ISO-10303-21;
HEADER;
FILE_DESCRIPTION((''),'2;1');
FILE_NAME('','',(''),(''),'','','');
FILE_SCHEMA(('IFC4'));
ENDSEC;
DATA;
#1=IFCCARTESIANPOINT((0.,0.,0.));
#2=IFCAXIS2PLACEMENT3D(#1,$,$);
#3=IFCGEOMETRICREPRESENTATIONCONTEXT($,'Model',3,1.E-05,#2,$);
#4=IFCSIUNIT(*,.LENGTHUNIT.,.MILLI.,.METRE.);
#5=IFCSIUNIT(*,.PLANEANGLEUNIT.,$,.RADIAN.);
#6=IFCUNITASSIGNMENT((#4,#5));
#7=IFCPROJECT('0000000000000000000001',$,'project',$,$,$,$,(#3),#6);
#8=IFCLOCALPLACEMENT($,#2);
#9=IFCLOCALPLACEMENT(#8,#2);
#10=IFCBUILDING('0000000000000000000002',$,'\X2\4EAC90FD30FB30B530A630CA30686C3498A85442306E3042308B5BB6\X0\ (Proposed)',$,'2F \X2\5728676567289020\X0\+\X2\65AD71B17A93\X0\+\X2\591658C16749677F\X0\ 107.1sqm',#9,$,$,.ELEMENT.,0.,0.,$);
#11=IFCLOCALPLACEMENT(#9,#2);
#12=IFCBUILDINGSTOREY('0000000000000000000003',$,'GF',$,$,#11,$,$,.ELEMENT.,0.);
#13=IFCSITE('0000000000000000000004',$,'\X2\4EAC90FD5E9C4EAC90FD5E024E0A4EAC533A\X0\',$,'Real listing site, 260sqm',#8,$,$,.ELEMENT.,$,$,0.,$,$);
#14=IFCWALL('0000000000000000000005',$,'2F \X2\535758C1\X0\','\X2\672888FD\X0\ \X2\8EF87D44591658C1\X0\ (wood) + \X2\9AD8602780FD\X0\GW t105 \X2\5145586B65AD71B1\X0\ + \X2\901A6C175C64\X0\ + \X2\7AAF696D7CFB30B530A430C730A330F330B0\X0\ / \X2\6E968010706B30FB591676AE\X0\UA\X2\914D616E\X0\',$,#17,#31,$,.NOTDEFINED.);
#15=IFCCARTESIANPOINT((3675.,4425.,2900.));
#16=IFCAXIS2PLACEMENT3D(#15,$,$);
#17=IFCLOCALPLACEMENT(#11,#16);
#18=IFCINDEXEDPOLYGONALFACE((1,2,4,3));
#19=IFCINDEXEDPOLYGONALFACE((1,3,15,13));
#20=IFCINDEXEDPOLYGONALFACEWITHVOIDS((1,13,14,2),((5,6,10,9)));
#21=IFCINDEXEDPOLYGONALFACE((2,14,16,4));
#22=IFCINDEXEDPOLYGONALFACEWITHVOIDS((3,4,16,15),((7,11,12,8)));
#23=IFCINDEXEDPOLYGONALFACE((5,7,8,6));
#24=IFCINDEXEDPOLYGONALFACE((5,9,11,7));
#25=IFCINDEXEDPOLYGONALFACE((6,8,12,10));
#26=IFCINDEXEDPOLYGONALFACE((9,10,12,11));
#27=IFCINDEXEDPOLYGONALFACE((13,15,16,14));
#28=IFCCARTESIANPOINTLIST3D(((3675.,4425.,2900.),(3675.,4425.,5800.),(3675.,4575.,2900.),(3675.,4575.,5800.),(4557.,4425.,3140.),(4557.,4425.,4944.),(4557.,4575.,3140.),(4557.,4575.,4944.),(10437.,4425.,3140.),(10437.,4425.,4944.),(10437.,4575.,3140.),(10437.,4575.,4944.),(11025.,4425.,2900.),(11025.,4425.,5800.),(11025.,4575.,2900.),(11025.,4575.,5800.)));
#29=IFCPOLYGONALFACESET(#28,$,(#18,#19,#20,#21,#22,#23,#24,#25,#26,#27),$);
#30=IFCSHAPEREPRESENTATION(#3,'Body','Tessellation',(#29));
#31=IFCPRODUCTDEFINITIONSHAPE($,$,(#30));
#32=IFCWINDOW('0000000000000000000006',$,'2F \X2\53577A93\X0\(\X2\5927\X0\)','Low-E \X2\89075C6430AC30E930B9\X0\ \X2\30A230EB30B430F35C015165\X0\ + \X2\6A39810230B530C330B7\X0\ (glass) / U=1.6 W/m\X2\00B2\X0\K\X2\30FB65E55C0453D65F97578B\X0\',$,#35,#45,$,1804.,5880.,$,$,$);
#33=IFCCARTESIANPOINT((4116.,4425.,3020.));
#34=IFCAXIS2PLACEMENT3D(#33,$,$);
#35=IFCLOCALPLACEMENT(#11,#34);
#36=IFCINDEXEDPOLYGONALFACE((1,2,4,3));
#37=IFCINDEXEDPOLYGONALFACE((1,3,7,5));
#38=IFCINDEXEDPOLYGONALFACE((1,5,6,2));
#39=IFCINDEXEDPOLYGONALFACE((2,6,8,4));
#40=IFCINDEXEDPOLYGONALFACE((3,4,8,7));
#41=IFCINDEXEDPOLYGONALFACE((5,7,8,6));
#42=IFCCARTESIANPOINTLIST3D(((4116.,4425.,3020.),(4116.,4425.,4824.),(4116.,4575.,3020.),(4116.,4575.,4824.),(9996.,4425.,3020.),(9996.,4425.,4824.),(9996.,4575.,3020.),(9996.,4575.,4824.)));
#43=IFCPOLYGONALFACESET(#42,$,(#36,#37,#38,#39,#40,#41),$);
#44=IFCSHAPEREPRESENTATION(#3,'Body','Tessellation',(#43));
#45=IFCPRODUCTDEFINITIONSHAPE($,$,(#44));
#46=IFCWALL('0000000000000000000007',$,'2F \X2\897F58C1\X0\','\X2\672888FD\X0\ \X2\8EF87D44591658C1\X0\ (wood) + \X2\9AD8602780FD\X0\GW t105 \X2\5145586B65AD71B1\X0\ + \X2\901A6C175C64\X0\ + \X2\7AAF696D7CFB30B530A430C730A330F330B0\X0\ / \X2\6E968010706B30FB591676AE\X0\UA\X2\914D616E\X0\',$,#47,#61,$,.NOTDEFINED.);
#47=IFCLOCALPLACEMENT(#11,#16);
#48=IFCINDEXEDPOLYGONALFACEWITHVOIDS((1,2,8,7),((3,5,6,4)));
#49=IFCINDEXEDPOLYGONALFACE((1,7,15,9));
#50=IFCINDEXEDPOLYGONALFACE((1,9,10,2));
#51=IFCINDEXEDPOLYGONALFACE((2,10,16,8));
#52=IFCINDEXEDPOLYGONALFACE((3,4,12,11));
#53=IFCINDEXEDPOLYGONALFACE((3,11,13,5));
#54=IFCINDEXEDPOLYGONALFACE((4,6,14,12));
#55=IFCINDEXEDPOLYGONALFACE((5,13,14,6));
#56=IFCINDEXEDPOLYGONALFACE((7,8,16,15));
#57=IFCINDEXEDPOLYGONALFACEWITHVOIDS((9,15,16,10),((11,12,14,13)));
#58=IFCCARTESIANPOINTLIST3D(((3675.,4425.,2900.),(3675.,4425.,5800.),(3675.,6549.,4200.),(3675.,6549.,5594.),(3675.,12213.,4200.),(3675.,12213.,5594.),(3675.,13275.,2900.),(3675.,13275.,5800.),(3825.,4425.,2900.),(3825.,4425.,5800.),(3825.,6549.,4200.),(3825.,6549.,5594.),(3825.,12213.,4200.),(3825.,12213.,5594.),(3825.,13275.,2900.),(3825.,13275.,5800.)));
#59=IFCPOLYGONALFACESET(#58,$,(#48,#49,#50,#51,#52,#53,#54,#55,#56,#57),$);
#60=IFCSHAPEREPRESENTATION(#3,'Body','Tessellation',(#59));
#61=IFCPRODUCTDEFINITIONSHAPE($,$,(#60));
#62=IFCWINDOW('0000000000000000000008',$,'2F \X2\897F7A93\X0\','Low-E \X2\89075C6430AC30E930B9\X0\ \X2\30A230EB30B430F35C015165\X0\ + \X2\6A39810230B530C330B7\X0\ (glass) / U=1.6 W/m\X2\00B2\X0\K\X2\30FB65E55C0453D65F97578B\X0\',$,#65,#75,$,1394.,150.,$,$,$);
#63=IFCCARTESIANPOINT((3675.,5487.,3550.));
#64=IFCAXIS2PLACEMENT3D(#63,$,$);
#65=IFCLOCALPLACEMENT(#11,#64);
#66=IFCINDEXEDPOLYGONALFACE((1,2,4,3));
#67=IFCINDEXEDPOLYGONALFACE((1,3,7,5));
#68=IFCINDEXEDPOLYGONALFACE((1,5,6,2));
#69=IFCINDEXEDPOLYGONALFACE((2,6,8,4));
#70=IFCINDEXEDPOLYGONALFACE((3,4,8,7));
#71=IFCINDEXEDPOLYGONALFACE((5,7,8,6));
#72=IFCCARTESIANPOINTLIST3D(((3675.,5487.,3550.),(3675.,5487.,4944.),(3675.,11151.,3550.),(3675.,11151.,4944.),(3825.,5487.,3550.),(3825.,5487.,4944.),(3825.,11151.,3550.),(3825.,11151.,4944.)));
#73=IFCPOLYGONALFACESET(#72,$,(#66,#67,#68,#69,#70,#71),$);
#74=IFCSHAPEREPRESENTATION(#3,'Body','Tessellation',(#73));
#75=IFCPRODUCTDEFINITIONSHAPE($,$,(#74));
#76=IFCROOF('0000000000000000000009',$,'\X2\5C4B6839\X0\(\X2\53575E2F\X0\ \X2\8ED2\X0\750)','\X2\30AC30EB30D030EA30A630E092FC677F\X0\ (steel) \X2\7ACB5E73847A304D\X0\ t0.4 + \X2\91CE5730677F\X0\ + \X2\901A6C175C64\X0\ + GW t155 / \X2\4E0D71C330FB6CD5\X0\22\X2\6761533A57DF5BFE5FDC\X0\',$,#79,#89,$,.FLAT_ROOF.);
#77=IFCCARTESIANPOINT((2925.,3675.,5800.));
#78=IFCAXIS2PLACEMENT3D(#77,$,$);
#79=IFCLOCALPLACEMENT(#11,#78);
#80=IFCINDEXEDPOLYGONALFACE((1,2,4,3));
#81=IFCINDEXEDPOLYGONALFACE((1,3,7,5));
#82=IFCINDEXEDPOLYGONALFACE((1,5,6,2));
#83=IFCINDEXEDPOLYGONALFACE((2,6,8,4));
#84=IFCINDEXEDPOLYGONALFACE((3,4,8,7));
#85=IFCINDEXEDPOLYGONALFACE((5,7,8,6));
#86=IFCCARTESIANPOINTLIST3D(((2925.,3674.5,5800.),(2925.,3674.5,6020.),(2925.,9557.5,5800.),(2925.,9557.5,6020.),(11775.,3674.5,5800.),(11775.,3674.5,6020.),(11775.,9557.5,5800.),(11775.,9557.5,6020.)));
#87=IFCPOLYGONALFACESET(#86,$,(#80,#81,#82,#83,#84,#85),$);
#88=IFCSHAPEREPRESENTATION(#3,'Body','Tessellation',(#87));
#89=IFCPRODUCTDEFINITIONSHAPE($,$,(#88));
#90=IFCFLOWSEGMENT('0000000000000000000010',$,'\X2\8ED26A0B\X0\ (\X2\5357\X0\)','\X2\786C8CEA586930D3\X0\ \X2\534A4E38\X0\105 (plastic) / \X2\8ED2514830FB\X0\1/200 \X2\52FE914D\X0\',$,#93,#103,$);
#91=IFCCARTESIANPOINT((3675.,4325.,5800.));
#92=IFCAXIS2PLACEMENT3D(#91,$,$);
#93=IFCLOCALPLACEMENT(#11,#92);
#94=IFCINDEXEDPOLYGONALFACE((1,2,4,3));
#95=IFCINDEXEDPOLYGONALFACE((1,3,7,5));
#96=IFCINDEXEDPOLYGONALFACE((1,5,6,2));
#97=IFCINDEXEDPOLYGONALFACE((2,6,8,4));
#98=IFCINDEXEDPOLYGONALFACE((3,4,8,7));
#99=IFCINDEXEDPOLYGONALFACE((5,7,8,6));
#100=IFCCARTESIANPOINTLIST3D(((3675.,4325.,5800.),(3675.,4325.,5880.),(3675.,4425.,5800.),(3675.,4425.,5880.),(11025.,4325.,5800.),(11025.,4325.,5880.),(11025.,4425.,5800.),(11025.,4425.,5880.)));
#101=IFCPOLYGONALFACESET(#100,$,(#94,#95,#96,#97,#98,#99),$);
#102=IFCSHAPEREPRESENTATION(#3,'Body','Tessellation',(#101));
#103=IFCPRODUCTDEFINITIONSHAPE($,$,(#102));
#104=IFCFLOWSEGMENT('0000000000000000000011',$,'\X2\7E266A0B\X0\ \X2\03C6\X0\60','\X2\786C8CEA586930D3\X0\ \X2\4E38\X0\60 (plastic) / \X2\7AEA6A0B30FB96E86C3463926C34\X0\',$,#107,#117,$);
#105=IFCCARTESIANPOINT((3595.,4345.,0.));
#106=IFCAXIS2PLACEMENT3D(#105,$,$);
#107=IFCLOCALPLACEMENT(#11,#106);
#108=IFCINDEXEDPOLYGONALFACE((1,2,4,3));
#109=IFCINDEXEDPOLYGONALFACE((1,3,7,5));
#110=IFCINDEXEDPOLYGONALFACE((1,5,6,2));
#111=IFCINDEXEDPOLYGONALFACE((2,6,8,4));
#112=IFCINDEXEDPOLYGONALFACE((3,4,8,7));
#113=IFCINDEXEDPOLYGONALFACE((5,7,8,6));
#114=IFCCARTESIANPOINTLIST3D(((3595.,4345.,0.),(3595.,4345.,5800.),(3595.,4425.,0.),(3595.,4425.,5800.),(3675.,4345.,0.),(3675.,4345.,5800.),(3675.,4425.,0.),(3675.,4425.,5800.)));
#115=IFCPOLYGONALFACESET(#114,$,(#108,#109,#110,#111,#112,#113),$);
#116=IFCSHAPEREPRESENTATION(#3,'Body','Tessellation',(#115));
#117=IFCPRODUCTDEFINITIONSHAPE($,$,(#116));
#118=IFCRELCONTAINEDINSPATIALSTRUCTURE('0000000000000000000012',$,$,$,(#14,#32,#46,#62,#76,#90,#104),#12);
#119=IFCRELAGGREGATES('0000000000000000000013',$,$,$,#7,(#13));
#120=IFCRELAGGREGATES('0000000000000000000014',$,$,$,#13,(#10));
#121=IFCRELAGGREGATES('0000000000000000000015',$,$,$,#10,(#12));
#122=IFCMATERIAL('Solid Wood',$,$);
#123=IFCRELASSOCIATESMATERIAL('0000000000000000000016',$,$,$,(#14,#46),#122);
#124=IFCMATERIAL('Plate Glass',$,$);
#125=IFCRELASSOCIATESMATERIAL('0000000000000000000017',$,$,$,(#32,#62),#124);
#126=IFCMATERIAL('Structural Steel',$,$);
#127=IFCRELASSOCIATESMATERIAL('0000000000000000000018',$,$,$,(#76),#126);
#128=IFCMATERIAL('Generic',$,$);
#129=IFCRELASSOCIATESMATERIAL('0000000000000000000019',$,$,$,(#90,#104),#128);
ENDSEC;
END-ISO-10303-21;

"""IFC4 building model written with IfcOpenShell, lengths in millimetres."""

from ifc_helpers import new_model, si_unit, frame, frame_2d, origin, place, context, project, spatial, rectangle, extrude, material, element, fill, save


model = new_model("IFC4")

# Units and contexts
model_context = context("Model", 3, precision=1e-05, world=origin())
ifc_project = project(units=[si_unit("LENGTHUNIT", "METRE", prefix="MILLI"), si_unit("PLANEANGLEUNIT", "RADIAN")], contexts=[model_context])

# Site, building, storey
site_placement = place(None, origin())
site = spatial("IfcSite", under=ifc_project, at=site_placement, Name="京都府京都市上京区", ObjectType="Real listing site, 260sqm", CompositionType="ELEMENT", RefElevation=0.0)
building_placement = place(site_placement, origin())
building = spatial("IfcBuilding", under=site, at=building_placement, Name="京都・サウナと水風呂のある家 (Proposed)", ObjectType="2F 在来木造+断熱窓+外壁杉板 107.1sqm", CompositionType="ELEMENT", ElevationOfRefHeight=0.0, ElevationOfTerrain=0.0)
storey_placement = place(building_placement, origin())
storey = spatial("IfcBuildingStorey", under=building, at=storey_placement, Name="GF", CompositionType="ELEMENT", Elevation=0.0)

# Shared definitions
ifc_material_1 = material(Name="Solid Wood")

# Shared definitions
ifc_material_2 = material(Name="Plate Glass")

# Walls, openings, windows
wall_1_placement = place(storey_placement, frame((3675.0, 4425.0, 2900.0)))
wall_1 = element("IfcWall", 1, at=wall_1_placement, inside=storey, material=ifc_material_1, Name="2F 南壁", Description="木製 軸組外壁 (wood) + 高性能GW t105 充填断熱 + 通気層 + 窯業系サイディング / 準耐火・外皮UA配慮", PredefinedType="NOTDEFINED", context=model_context, shape_type="SweptSolid", body=[
    extrude(rectangle(XDim=7350.0, YDim=150.0, at=frame_2d((3675.0, 75.0))), frame((3675.0, 4425.0, 2900.0)), (0.0, 0.0, 1.0), 2900.0),
])
opening_1_placement = place(storey_placement, frame((4116.0, 4425.0, 3020.0)))
opening_1 = element("IfcOpeningElement", 2, at=opening_1_placement, cuts=wall_1, PredefinedType="NOTDEFINED", context=model_context, shape_type="SweptSolid", body=[
    extrude(rectangle(XDim=5880.0, YDim=150.0, at=frame_2d((2940.0, 75.0))), frame((4116.0, 4425.0, 3020.0)), (0.0, 0.0, 1.0), 1804.0),
])
window_1_placement = place(storey_placement, frame((4116.0, 4425.0, 3020.0)))
window_1 = element("IfcWindow", 3, at=window_1_placement, inside=storey, material=ifc_material_2, Name="2F 南窓(大)", Description="Low-E 複層ガラス アルゴン封入 + 樹脂サッシ (glass) / U=1.6 W/m²K・日射取得型", OverallHeight=1804.0, OverallWidth=5880.0, context=model_context, shape_type="SweptSolid", body=[
    extrude(rectangle(XDim=5880.0, YDim=150.0, at=frame_2d((2940.0, 75.0))), frame((4116.0, 4425.0, 3020.0)), (0.0, 0.0, 1.0), 1804.0),
])
fill(opening_1, window_1)
wall_2_placement = place(storey_placement, frame((3675.0, 4425.0, 2900.0)))
wall_2 = element("IfcWall", 4, at=wall_2_placement, inside=storey, material=ifc_material_1, Name="2F 西壁", Description="木製 軸組外壁 (wood) + 高性能GW t105 充填断熱 + 通気層 + 窯業系サイディング / 準耐火・外皮UA配慮", PredefinedType="NOTDEFINED", context=model_context, shape_type="SweptSolid", body=[
    extrude(rectangle(XDim=150.0, YDim=8850.0, at=frame_2d((75.0, 4425.0))), frame((3675.0, 4425.0, 2900.0)), (0.0, 0.0, 1.0), 2900.0),
])
opening_2_placement = place(storey_placement, frame((3675.0, 5487.0, 3550.0)))
opening_2 = element("IfcOpeningElement", 5, at=opening_2_placement, cuts=wall_2, PredefinedType="NOTDEFINED", context=model_context, shape_type="SweptSolid", body=[
    extrude(rectangle(XDim=150.0, YDim=5664.0, at=frame_2d((75.0, 2832.0))), frame((3675.0, 5487.0, 3550.0)), (0.0, 0.0, 1.0), 1394.0),
])
window_2_placement = place(storey_placement, frame((3675.0, 5487.0, 3550.0)))
window_2 = element("IfcWindow", 6, at=window_2_placement, inside=storey, material=ifc_material_2, Name="2F 西窓", Description="Low-E 複層ガラス アルゴン封入 + 樹脂サッシ (glass) / U=1.6 W/m²K・日射取得型", OverallHeight=1394.0, OverallWidth=150.0, context=model_context, shape_type="SweptSolid", body=[
    extrude(rectangle(XDim=150.0, YDim=5664.0, at=frame_2d((75.0, 2832.0))), frame((3675.0, 5487.0, 3550.0)), (0.0, 0.0, 1.0), 1394.0),
])
fill(opening_2, window_2)

# Roof
ifc_material_3 = material(Name="Structural Steel")
for number, where, name in (
    (7, (2925.0, 3675.0, 5800.0), "屋根(南帯 軒750)"),
):
    element("IfcRoof", number, at=place(storey_placement, frame(where)), inside=storey, material=ifc_material_3, Name=name, Description="ガルバリウム鋼板 (steel) 立平葺き t0.4 + 野地板 + 通気層 + GW t155 / 不燃・法22条区域対応", PredefinedType="FLAT_ROOF", context=model_context, shape_type="SweptSolid", body=[
        extrude(rectangle(XDim=8850.0, YDim=5883.0, at=frame_2d((4425.0, 2941.0))), frame((2925.0, 3675.0, 5800.0)), (0.0, 0.0, 1.0), 220.0),
    ])

# Flow segments
ifc_material_4 = material(Name="Generic")
flow_segment_1_placement = place(storey_placement, frame((3675.0, 4325.0, 5800.0)))
element("IfcFlowSegment", 8, at=flow_segment_1_placement, inside=storey, material=ifc_material_4, Name="軒樋 (南)", Description="硬質塩ビ 半丸105 (plastic) / 軒先・1/200 勾配", context=model_context, shape_type="SweptSolid", body=[
    extrude(rectangle(XDim=7350.0, YDim=100.0, at=frame_2d((3675.0, 50.0))), frame((3675.0, 4325.0, 5800.0)), (0.0, 0.0, 1.0), 80.0),
])
flow_segment_2_placement = place(storey_placement, frame((3595.0, 4345.0, 0.0)))
element("IfcFlowSegment", 9, at=flow_segment_2_placement, inside=storey, material=ifc_material_4, Name="縦樋 φ60", Description="硬質塩ビ 丸60 (plastic) / 竪樋・雨水排水", context=model_context, shape_type="SweptSolid", body=[
    extrude(rectangle(XDim=80.0, YDim=80.0, at=frame_2d((40.0, 40.0))), frame((3595.0, 4345.0, 0.0)), (0.0, 0.0, 1.0), 5800.0),
])

save(model, "model.ifc")
